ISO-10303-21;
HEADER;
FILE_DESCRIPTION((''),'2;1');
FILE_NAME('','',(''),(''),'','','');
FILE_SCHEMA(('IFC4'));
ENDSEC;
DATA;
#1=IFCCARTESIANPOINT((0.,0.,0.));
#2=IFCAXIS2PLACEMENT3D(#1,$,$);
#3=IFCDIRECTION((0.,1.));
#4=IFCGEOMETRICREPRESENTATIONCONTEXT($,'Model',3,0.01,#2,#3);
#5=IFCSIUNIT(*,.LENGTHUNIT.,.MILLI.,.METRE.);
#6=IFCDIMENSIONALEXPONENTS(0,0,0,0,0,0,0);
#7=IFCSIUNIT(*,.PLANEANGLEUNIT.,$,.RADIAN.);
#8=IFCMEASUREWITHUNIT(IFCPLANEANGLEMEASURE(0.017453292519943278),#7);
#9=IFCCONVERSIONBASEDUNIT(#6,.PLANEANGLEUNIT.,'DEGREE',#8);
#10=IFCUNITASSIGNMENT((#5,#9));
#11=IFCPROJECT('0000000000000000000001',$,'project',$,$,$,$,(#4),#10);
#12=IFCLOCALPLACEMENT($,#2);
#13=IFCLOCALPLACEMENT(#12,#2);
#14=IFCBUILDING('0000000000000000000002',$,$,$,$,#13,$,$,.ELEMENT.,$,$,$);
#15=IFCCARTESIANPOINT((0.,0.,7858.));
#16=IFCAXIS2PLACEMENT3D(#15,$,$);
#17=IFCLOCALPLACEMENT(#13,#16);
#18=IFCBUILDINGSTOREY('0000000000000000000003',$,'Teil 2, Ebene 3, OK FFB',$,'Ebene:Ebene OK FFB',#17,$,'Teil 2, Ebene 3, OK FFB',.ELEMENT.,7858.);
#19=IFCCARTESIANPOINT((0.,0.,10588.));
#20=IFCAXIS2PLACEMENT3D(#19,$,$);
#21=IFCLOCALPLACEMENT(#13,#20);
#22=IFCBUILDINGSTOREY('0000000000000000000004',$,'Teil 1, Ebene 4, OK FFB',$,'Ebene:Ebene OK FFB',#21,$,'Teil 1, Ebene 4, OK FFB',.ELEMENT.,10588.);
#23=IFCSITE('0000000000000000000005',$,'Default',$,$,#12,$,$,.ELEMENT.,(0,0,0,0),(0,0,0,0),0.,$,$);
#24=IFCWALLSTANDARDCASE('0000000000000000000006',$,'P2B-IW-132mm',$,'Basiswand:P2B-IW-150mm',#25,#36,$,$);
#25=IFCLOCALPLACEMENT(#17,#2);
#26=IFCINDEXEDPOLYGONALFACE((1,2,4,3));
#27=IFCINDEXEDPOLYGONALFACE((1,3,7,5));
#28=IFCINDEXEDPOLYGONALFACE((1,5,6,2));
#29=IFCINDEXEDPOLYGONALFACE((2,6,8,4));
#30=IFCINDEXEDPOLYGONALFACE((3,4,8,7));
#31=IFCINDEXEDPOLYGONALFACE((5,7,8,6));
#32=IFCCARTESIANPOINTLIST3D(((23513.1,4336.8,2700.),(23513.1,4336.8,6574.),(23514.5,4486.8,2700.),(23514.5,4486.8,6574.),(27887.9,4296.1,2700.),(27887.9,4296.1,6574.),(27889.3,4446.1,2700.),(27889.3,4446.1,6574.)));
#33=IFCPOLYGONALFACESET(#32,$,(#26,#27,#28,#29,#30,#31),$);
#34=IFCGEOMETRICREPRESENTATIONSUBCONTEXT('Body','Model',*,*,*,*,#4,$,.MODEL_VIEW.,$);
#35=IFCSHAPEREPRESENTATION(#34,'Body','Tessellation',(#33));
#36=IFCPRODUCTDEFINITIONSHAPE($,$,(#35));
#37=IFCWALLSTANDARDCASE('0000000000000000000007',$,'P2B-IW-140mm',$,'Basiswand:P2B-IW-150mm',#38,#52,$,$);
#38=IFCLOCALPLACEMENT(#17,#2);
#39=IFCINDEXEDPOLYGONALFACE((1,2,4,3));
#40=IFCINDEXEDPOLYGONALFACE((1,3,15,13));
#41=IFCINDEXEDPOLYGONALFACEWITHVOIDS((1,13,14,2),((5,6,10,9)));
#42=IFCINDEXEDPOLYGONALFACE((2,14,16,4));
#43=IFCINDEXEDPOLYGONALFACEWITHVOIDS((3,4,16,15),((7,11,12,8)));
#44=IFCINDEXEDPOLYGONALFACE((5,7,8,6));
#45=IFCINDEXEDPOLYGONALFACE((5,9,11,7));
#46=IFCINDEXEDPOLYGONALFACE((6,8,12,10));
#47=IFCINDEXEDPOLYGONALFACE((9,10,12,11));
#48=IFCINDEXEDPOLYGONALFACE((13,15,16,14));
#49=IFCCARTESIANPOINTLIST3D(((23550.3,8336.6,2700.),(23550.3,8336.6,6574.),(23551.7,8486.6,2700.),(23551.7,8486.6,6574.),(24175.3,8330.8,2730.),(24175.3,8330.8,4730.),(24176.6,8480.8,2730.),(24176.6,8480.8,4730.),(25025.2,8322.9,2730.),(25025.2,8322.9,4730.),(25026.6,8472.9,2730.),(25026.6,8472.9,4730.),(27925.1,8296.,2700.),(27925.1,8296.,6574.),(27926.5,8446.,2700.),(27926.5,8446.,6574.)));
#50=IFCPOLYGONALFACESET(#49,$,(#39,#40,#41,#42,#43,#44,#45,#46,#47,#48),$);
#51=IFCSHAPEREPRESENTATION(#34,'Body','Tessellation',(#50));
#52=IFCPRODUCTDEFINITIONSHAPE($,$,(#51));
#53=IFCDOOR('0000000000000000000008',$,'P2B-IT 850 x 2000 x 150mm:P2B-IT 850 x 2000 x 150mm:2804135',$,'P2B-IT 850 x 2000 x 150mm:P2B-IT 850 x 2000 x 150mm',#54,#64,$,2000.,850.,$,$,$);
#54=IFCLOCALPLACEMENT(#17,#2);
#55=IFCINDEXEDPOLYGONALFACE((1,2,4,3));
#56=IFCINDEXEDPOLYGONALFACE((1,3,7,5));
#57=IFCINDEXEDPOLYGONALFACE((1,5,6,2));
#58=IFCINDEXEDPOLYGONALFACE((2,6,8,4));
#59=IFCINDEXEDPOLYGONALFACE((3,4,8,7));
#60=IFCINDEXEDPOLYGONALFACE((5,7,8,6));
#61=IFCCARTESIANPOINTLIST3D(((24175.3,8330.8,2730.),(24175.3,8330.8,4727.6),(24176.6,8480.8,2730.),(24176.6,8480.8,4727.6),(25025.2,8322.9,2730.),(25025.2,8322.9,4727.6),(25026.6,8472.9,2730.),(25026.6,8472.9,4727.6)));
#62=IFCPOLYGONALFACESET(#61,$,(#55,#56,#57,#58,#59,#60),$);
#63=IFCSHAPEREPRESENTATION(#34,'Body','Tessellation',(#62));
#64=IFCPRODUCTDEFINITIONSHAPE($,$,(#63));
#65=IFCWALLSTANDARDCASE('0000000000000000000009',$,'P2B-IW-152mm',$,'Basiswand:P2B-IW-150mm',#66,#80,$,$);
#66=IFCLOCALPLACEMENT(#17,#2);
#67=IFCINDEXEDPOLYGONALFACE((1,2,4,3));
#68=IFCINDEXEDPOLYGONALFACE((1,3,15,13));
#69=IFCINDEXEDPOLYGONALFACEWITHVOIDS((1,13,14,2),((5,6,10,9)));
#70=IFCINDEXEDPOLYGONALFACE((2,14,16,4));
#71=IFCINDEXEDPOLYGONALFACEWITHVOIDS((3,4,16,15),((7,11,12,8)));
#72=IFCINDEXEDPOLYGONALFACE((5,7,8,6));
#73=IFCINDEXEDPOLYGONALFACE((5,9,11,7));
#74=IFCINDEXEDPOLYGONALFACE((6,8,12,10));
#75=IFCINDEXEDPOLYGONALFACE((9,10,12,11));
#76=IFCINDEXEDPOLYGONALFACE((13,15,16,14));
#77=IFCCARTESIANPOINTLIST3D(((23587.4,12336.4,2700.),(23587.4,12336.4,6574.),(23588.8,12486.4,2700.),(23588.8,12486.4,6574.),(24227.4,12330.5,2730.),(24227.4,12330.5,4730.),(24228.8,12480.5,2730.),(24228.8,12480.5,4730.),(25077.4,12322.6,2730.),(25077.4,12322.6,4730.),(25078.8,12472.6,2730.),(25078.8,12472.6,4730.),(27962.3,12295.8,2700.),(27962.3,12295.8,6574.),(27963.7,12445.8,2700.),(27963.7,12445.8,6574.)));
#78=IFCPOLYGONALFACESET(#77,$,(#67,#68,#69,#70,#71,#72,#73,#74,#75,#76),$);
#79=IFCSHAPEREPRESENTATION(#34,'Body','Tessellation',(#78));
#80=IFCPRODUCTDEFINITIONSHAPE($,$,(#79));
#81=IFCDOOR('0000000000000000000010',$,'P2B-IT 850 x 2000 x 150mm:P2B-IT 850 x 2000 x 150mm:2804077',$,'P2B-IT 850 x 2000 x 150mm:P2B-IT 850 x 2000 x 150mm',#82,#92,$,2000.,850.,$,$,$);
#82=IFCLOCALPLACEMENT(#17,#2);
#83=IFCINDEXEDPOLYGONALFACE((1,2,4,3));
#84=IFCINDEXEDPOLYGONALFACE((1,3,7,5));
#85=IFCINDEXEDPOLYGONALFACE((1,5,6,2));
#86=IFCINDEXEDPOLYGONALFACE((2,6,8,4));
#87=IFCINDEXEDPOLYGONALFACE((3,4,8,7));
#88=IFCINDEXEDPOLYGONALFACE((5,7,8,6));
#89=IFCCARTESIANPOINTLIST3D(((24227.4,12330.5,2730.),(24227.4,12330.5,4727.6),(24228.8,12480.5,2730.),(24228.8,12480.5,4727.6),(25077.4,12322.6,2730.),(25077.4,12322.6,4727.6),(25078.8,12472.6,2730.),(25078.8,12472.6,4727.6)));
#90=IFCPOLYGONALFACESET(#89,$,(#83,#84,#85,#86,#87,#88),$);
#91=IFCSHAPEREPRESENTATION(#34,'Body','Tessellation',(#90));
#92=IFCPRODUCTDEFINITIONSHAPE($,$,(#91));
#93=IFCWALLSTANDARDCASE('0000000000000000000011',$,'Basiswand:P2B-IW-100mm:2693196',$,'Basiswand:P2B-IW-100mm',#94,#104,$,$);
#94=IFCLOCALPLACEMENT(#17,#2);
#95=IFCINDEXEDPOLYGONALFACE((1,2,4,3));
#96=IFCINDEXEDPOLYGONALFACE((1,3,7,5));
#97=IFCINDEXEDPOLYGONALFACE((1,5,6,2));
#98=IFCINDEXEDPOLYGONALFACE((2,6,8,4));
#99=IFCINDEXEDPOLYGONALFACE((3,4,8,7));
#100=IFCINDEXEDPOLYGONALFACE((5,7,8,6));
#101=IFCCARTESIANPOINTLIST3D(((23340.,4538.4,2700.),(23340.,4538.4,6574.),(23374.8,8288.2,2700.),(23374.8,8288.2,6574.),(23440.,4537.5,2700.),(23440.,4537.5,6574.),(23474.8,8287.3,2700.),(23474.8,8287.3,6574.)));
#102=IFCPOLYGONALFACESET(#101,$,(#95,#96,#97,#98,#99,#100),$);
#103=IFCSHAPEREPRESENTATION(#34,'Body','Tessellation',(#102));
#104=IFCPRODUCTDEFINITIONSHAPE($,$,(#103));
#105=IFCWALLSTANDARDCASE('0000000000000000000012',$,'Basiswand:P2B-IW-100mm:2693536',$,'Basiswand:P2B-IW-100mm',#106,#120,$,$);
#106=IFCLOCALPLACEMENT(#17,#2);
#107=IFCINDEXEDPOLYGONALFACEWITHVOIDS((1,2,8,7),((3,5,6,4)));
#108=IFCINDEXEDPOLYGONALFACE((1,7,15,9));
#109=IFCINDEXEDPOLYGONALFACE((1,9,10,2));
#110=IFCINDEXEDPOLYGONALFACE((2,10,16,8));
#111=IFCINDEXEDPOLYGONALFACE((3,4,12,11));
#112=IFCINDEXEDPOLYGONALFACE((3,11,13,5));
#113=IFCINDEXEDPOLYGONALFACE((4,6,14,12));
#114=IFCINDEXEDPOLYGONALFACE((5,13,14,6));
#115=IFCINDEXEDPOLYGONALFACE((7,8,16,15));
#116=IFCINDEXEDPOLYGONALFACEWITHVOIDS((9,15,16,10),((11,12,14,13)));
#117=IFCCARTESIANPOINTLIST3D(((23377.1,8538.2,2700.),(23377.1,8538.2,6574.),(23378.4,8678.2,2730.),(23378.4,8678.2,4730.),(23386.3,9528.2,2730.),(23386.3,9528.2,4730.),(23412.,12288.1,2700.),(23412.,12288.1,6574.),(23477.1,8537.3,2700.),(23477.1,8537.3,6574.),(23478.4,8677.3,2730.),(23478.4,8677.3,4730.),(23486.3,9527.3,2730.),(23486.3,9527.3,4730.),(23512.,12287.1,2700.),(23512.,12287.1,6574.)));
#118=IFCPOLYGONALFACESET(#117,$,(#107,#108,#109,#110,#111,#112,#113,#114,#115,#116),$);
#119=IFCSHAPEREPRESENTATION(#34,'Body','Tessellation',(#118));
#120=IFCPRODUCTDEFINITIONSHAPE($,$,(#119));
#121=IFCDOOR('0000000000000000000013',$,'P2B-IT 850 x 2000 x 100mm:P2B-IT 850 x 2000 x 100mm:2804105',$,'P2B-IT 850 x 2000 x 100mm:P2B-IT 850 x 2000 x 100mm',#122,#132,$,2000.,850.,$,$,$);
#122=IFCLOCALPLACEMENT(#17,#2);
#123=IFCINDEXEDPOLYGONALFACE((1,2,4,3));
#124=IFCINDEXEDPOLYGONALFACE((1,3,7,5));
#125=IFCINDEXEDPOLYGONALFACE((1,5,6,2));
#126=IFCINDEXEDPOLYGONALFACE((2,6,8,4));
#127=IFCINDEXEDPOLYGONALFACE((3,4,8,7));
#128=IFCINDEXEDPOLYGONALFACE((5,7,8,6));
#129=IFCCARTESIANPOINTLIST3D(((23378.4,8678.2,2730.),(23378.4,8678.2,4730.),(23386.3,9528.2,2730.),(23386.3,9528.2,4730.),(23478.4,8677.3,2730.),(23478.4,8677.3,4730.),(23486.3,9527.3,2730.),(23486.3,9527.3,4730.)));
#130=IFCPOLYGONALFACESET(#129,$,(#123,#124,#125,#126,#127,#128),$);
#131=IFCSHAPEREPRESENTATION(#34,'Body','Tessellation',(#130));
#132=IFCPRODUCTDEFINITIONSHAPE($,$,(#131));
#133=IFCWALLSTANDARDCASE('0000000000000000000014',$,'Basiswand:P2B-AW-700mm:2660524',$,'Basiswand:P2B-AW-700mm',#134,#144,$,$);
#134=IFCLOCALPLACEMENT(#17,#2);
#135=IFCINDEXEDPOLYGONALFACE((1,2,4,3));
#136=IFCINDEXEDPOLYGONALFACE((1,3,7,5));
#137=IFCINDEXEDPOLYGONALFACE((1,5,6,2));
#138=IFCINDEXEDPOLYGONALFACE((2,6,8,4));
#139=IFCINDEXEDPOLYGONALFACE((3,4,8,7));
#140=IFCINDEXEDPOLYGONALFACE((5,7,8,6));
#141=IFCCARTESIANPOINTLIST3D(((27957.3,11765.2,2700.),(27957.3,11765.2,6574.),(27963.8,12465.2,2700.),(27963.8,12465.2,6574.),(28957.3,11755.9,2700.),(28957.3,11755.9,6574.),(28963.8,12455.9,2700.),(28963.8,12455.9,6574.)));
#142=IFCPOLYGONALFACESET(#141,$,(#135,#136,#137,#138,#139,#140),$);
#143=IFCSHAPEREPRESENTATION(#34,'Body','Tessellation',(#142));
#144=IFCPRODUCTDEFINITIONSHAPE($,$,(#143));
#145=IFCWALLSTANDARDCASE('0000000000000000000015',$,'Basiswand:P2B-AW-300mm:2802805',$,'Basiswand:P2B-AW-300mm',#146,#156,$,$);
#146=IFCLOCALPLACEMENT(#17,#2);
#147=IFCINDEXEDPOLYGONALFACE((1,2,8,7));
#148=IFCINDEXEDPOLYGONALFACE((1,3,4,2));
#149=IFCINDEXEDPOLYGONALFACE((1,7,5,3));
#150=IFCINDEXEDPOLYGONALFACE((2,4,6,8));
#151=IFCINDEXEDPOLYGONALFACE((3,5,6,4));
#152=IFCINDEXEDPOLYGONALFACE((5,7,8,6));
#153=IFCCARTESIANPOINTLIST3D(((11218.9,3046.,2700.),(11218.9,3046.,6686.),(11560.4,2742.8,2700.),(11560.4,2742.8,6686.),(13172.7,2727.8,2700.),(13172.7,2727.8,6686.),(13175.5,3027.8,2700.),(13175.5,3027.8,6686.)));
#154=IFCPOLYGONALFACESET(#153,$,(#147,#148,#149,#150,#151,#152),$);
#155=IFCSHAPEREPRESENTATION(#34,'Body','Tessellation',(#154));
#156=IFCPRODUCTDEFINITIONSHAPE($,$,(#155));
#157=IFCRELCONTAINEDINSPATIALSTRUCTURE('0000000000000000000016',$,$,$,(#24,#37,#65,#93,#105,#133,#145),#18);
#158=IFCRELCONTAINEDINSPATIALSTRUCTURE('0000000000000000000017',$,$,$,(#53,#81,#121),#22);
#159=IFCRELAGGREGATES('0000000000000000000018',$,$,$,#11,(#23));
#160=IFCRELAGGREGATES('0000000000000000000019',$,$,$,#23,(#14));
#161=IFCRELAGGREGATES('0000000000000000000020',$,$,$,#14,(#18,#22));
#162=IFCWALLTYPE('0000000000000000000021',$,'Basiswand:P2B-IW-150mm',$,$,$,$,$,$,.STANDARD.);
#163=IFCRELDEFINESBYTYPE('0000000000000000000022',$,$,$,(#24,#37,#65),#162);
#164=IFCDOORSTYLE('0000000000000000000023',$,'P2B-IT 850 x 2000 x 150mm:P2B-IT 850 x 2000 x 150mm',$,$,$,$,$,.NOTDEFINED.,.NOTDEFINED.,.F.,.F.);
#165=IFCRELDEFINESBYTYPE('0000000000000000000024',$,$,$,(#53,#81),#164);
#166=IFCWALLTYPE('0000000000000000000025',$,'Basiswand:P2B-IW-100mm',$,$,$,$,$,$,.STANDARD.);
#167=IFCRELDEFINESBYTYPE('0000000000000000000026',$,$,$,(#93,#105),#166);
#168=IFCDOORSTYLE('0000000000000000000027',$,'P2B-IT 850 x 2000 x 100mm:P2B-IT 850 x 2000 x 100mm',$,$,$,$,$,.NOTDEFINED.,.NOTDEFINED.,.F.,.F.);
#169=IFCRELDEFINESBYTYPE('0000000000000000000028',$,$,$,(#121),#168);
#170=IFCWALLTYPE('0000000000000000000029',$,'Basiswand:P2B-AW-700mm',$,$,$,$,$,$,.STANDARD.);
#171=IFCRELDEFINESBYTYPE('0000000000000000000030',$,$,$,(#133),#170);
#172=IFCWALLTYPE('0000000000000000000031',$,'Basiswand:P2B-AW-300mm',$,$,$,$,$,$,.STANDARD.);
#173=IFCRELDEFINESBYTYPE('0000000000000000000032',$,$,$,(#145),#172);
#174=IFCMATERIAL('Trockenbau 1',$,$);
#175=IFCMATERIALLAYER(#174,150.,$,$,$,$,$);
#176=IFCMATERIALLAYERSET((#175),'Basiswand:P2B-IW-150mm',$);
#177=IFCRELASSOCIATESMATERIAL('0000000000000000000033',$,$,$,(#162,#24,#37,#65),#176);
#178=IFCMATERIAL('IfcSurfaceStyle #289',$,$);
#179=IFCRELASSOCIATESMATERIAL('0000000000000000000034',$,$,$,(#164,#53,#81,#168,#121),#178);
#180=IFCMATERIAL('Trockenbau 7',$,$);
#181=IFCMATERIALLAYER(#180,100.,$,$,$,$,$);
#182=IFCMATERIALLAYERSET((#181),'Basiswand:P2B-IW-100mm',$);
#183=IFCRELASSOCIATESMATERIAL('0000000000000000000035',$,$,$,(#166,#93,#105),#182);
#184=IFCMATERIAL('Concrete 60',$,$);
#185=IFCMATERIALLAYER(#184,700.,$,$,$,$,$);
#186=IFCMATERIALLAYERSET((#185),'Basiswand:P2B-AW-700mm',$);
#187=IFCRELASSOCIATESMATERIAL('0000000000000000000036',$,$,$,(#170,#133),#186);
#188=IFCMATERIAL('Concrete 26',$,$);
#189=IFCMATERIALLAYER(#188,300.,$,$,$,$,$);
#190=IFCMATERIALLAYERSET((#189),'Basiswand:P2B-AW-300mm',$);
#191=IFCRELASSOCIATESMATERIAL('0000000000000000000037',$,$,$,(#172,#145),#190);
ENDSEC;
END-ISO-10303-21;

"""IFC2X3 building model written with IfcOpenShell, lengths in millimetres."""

from ifc_helpers import new_model, entity, si_unit, converted_unit, direction, frame, frame_2d, origin, origin_2d_with_axis, place, context, subcontext, project, spatial, polyline, rectangle, outline, extrude, source, transform, mapped, material, layer, layer_set, layer_usage, type_object, type_shapes, element, fill, save


model = new_model("IFC2X3")

# Units and contexts
model_context = context("Model", 3, precision=0.01, world=origin(), true_north=direction((0.0, 1.0)))
body_context = subcontext(model_context, "Body", "Model", "MODEL_VIEW")
ifc_project = project(units=[si_unit("LENGTHUNIT", "METRE", prefix="MILLI"), converted_unit("PLANEANGLEUNIT", "DEGREE", entity("IfcPlaneAngleMeasure", 0.017453292519943278), si_unit("PLANEANGLEUNIT", "RADIAN"), dimensions=[0, 0, 0, 0, 0, 0, 0])], contexts=[model_context])

# Site, building, storey
site_placement = place(None, origin())
site = spatial("IfcSite", under=ifc_project, at=site_placement, Name="Default", CompositionType="ELEMENT", RefLatitude=(0, 0, 0, 0), RefLongitude=(0, 0, 0, 0), RefElevation=0.0)
building_placement = place(site_placement, origin())
building = spatial("IfcBuilding", under=site, at=building_placement, CompositionType="ELEMENT")
storey_1_placement = place(building_placement, frame((0.0, 0.0, 7858.0)))
storey_1 = spatial("IfcBuildingStorey", under=building, at=storey_1_placement, Name="Teil 2, Ebene 3, OK FFB", ObjectType="Ebene:Ebene OK FFB", LongName="Teil 2, Ebene 3, OK FFB", CompositionType="ELEMENT", Elevation=7858.0)

# Wall
ifc_material_1 = material(Name="Trockenbau 1")
ifc_layer_1 = layer(ifc_material_1, 150.0)
ifc_layer_set_1 = layer_set([ifc_layer_1], Name="Basiswand:P2B-IW-150mm")
ifc_layer_usage_1 = layer_usage(ifc_layer_set_1, "AXIS2", "NEGATIVE", 75.0)
wall_type_1 = type_object("IfcWallType", Name="Basiswand:P2B-IW-150mm", PredefinedType="STANDARD", material=ifc_layer_set_1)
wall_1_placement = place(storey_1_placement, frame((27888.6, 4371.1, 2700.0), z_axis=(0.0, 0.0, 1.0), x_axis=(-0.999957, 0.00929, 0.0)))
element("IfcWallStandardCase", 1, at=wall_1_placement, inside=storey_1, type_object=wall_type_1, material=ifc_layer_usage_1, Name="P2B-IW-132mm", ObjectType="Basiswand:P2B-IW-150mm", context=body_context, shape_type="SweptSolid", body=[
    extrude(rectangle(XDim=4375.0, YDim=150.0, at=frame_2d((2187.5, 0.0), x_axis=(-1.0, 0.0))), origin(), (0.0, 0.0, 1.0), 3874.0),
])

# Wall, opening
ifc_layer_usage_2 = layer_usage(ifc_layer_set_1, "AXIS2", "NEGATIVE", 75.0)
wall_2_placement = place(storey_1_placement, frame((23551.0, 8411.6, 2700.0), z_axis=(0.0, 0.0, 1.0), x_axis=(0.999957, -0.00929, 0.0)))
wall_2 = element("IfcWallStandardCase", 2, at=wall_2_placement, inside=storey_1, type_object=wall_type_1, material=ifc_layer_usage_2, Name="P2B-IW-140mm", ObjectType="Basiswand:P2B-IW-150mm", context=body_context, shape_type="SweptSolid", body=[
    extrude(rectangle(XDim=4375.0, YDim=150.0, at=frame_2d((2187.5, 0.0), x_axis=(-1.0, 0.0))), origin(), (0.0, 0.0, 1.0), 3874.0),
])
opening_1_placement = place(wall_2_placement, frame((-23471.8, -8630.1, 30.0), z_axis=(0.0, 0.0, 1.0), x_axis=(0.999957, 0.00929, 0.0)))
opening_1 = element("IfcOpeningElement", 3, at=opening_1_placement, cuts=wall_2, ObjectType="Opening", context=body_context, shape_type="SweptSolid", body=[
    extrude(rectangle(XDim=2000.0, YDim=850.0, at=origin_2d_with_axis()), frame((24600.2, 8326.9, 1000.0), z_axis=(0.00929, 0.999957, 0.0), x_axis=(0.0, 0.0, -1.0)), (0.0, 0.0, 1.0), 150.0),
])

# Shared definitions
storey_2_placement = place(building_placement, frame((0.0, 0.0, 10588.0)))
storey_2 = spatial("IfcBuildingStorey", under=building, at=storey_2_placement, Name="Teil 1, Ebene 4, OK FFB", ObjectType="Ebene:Ebene OK FFB", LongName="Teil 1, Ebene 4, OK FFB", CompositionType="ELEMENT", Elevation=10588.0)

# Door
ifc_material_2 = material(Name="IfcSurfaceStyle #289")
door_style_1 = type_object("IfcDoorStyle", Name="P2B-IT 850 x 2000 x 150mm:P2B-IT 850 x 2000 x 150mm", ConstructionType="NOTDEFINED", OperationType="NOTDEFINED", ParameterTakesPrecedence=False, Sizeable=False, material=ifc_material_2)
shared_shape_1 = source(origin(), body_context, "Body", "SweptSolid", [
    extrude(rectangle(XDim=150.0, YDim=850.0, at=frame_2d((0.0, 0.0), x_axis=(1.0, 0.0))), frame((425.0, 75.0, 0.0), z_axis=(0.0, 0.0, 1.0), x_axis=(0.0, 1.0, 0.0)), (0.0, 0.0, 1.0), 1997.6),
])
type_shapes(door_style_1, [shared_shape_1])
door_1_placement = place(opening_1_placement, frame((25026.6, 8472.9, 0.0), z_axis=(0.0, 0.0, 1.0), x_axis=(-0.999957, 0.00929, 0.0)))
door_1 = element("IfcDoor", 4, at=door_1_placement, inside=storey_2, type_object=door_style_1, material=ifc_material_2, Name="P2B-IT 850 x 2000 x 150mm:P2B-IT 850 x 2000 x 150mm:2804135", ObjectType="P2B-IT 850 x 2000 x 150mm:P2B-IT 850 x 2000 x 150mm", OverallHeight=2000.0, OverallWidth=850.0, context=body_context, shape_type="MappedRepresentation", body=[
    mapped(shared_shape_1, transform((0.0, 0.0, 0.0), scale=1.0)),
])
fill(opening_1, door_1)

# Wall, opening, door
ifc_layer_usage_3 = layer_usage(ifc_layer_set_1, "AXIS2", "NEGATIVE", 75.0)
wall_3_placement = place(storey_1_placement, frame((23588.1, 12411.4, 2700.0), z_axis=(0.0, 0.0, 1.0), x_axis=(0.999957, -0.00929, 0.0)))
wall_3 = element("IfcWallStandardCase", 5, at=wall_3_placement, inside=storey_1, type_object=wall_type_1, material=ifc_layer_usage_3, Name="P2B-IW-152mm", ObjectType="Basiswand:P2B-IW-150mm", context=body_context, shape_type="SweptSolid", body=[
    extrude(rectangle(XDim=4375.0, YDim=150.0, at=frame_2d((2187.5, 0.0), x_axis=(-1.0, 0.0))), origin(), (0.0, 0.0, 1.0), 3874.0),
])
opening_2_placement = place(wall_3_placement, frame((-23471.8, -12630.0, 30.0), z_axis=(0.0, 0.0, 1.0), x_axis=(0.999957, 0.00929, 0.0)))
opening_2 = element("IfcOpeningElement", 6, at=opening_2_placement, cuts=wall_3, ObjectType="Opening", context=body_context, shape_type="SweptSolid", body=[
    extrude(rectangle(XDim=2000.0, YDim=850.0, at=frame_2d((0.0, 0.0), x_axis=(1.0, 0.0))), frame((24652.4, 12326.6, 1000.0), z_axis=(0.00929, 0.999957, 0.0), x_axis=(0.0, 0.0, -1.0)), (0.0, 0.0, 1.0), 150.0),
])
door_2_placement = place(opening_2_placement, frame((25078.8, 12472.6, 0.0), z_axis=(0.0, 0.0, 1.0), x_axis=(-0.999957, 0.00929, 0.0)))
door_2 = element("IfcDoor", 7, at=door_2_placement, inside=storey_2, type_object=door_style_1, material=ifc_material_2, Name="P2B-IT 850 x 2000 x 150mm:P2B-IT 850 x 2000 x 150mm:2804077", ObjectType="P2B-IT 850 x 2000 x 150mm:P2B-IT 850 x 2000 x 150mm", OverallHeight=2000.0, OverallWidth=850.0, context=body_context, shape_type="MappedRepresentation", body=[
    mapped(shared_shape_1, transform((0.0, 0.0, 0.0), scale=1.0)),
])
fill(opening_2, door_2)

# Wall
ifc_material_3 = material(Name="Trockenbau 7")
ifc_layer_2 = layer(ifc_material_3, 100.0)
ifc_layer_set_2 = layer_set([ifc_layer_2], Name="Basiswand:P2B-IW-100mm")
ifc_layer_usage_4 = layer_usage(ifc_layer_set_2, "AXIS2", "NEGATIVE", 50.0)
wall_type_2 = type_object("IfcWallType", Name="Basiswand:P2B-IW-100mm", PredefinedType="STANDARD", material=ifc_layer_set_2)
wall_4_placement = place(storey_1_placement, frame((23390.0, 4537.9, 2700.0), z_axis=(0.0, 0.0, 1.0), x_axis=(0.009291, 0.999957, 0.0)))
element("IfcWallStandardCase", 8, at=wall_4_placement, inside=storey_1, type_object=wall_type_2, material=ifc_layer_usage_4, Name="Basiswand:P2B-IW-100mm:2693196", ObjectType="Basiswand:P2B-IW-100mm", context=body_context, shape_type="SweptSolid", body=[
    extrude(rectangle(XDim=3750.0, YDim=100.0, at=frame_2d((1875.0, 0.0), x_axis=(-1.0, 0.0))), origin(), (0.0, 0.0, 1.0), 3874.0),
])

# Wall, opening, door
ifc_layer_usage_5 = layer_usage(ifc_layer_set_2, "AXIS2", "NEGATIVE", 50.0)
wall_5_placement = place(storey_1_placement, frame((23427.1, 8537.8, 2700.0), z_axis=(0.0, 0.0, 1.0), x_axis=(0.009291, 0.999957, 0.0)))
wall_5 = element("IfcWallStandardCase", 9, at=wall_5_placement, inside=storey_1, type_object=wall_type_2, material=ifc_layer_usage_5, Name="Basiswand:P2B-IW-100mm:2693536", ObjectType="Basiswand:P2B-IW-100mm", context=body_context, shape_type="SweptSolid", body=[
    extrude(rectangle(XDim=3750.0, YDim=100.0, at=frame_2d((1875.0, 0.0), x_axis=(-1.0, 0.0))), origin(), (0.0, 0.0, 1.0), 3874.0),
])
opening_3_placement = place(wall_5_placement, frame((-8755.1, 23346.8, 30.0), z_axis=(0.0, 0.0, 1.0), x_axis=(0.009291, -0.999957, 0.0)))
opening_3 = element("IfcOpeningElement", 10, at=opening_3_placement, cuts=wall_5, ObjectType="Opening", context=body_context, shape_type="SweptSolid", body=[
    extrude(rectangle(XDim=2000.0, YDim=850.0, at=frame_2d((0.0, 0.0), x_axis=(1.0, 0.0))), frame((23507.4, 9102.1, 1000.0), z_axis=(-0.999957, 0.009291, 0.0), x_axis=(0.0, 0.0, -1.0)), (0.0, 0.0, 1.0), 150.0),
])
door_style_2 = type_object("IfcDoorStyle", Name="P2B-IT 850 x 2000 x 100mm:P2B-IT 850 x 2000 x 100mm", ConstructionType="NOTDEFINED", OperationType="NOTDEFINED", ParameterTakesPrecedence=False, Sizeable=False, material=ifc_material_2)
shared_shape_2 = source(origin(), body_context, "Body", "SweptSolid", [
    extrude(rectangle(XDim=100.0, YDim=850.0, at=origin_2d_with_axis()), frame((425.0, -75.0, 0.0), z_axis=(0.0, 0.0, 1.0), x_axis=(0.0, 1.0, 0.0)), (0.0, 0.0, 1.0), 2000.0),
])
type_shapes(door_style_2, [shared_shape_2])
door_3_placement = place(opening_3_placement, frame((23353.4, 8678.5, 0.0), z_axis=(0.0, 0.0, 1.0), x_axis=(0.009291, 0.999957, 0.0)))
door_3 = element("IfcDoor", 11, at=door_3_placement, inside=storey_2, type_object=door_style_2, material=ifc_material_2, Name="P2B-IT 850 x 2000 x 100mm:P2B-IT 850 x 2000 x 100mm:2804105", ObjectType="P2B-IT 850 x 2000 x 100mm:P2B-IT 850 x 2000 x 100mm", OverallHeight=2000.0, OverallWidth=850.0, context=body_context, shape_type="MappedRepresentation", body=[
    mapped(shared_shape_2, transform((0.0, 0.0, 0.0), scale=1.0)),
])
fill(opening_3, door_3)

# Walls
ifc_material_4 = material(Name="Concrete 60")
ifc_layer_3 = layer(ifc_material_4, 700.0)
ifc_layer_set_3 = layer_set([ifc_layer_3], Name="Basiswand:P2B-AW-700mm")
ifc_layer_usage_6 = layer_usage(ifc_layer_set_3, "AXIS2", "POSITIVE", -350.0)
wall_type_3 = type_object("IfcWallType", Name="Basiswand:P2B-AW-700mm", PredefinedType="STANDARD", material=ifc_layer_set_3)
wall_6_placement = place(storey_1_placement, frame((27960.6, 12115.2, 2700.0), z_axis=(0.0, 0.0, 1.0), x_axis=(0.999957, -0.009291, 0.0)))
element("IfcWallStandardCase", 12, at=wall_6_placement, inside=storey_1, type_object=wall_type_3, material=ifc_layer_usage_6, Name="Basiswand:P2B-AW-700mm:2660524", ObjectType="Basiswand:P2B-AW-700mm", context=body_context, shape_type="SweptSolid", body=[
    extrude(rectangle(XDim=1000.0, YDim=700.0, at=frame_2d((500.0, 0.0), x_axis=(-1.0, 0.0))), origin(), (0.0, 0.0, 1.0), 3874.0),
])
ifc_material_5 = material(Name="Concrete 26")
ifc_layer_4 = layer(ifc_material_5, 300.0)
ifc_layer_set_4 = layer_set([ifc_layer_4], Name="Basiswand:P2B-AW-300mm")
ifc_layer_usage_7 = layer_usage(ifc_layer_set_4, "AXIS2", "NEGATIVE", 150.0)
wall_type_4 = type_object("IfcWallType", Name="Basiswand:P2B-AW-300mm", PredefinedType="STANDARD", material=ifc_layer_set_4)
wall_7_placement = place(storey_1_placement, frame((13174.1, 2877.8, 2700.0), z_axis=(0.0, 0.0, 1.0), x_axis=(-0.999957, 0.009291, 0.0)))
element("IfcWallStandardCase", 13, at=wall_7_placement, inside=storey_1, type_object=wall_type_4, material=ifc_layer_usage_7, Name="Basiswand:P2B-AW-300mm:2802805", ObjectType="Basiswand:P2B-AW-300mm", context=body_context, shape_type="SweptSolid", body=[
    extrude(outline(polyline([(1956.7, -150.0), (1612.4, 150.0), (0.0, 150.0), (0.0, -150.0), (1956.7, -150.0)])), origin(), (0.0, 0.0, 1.0), 3986.0),
])

save(model, "model.ifc")
